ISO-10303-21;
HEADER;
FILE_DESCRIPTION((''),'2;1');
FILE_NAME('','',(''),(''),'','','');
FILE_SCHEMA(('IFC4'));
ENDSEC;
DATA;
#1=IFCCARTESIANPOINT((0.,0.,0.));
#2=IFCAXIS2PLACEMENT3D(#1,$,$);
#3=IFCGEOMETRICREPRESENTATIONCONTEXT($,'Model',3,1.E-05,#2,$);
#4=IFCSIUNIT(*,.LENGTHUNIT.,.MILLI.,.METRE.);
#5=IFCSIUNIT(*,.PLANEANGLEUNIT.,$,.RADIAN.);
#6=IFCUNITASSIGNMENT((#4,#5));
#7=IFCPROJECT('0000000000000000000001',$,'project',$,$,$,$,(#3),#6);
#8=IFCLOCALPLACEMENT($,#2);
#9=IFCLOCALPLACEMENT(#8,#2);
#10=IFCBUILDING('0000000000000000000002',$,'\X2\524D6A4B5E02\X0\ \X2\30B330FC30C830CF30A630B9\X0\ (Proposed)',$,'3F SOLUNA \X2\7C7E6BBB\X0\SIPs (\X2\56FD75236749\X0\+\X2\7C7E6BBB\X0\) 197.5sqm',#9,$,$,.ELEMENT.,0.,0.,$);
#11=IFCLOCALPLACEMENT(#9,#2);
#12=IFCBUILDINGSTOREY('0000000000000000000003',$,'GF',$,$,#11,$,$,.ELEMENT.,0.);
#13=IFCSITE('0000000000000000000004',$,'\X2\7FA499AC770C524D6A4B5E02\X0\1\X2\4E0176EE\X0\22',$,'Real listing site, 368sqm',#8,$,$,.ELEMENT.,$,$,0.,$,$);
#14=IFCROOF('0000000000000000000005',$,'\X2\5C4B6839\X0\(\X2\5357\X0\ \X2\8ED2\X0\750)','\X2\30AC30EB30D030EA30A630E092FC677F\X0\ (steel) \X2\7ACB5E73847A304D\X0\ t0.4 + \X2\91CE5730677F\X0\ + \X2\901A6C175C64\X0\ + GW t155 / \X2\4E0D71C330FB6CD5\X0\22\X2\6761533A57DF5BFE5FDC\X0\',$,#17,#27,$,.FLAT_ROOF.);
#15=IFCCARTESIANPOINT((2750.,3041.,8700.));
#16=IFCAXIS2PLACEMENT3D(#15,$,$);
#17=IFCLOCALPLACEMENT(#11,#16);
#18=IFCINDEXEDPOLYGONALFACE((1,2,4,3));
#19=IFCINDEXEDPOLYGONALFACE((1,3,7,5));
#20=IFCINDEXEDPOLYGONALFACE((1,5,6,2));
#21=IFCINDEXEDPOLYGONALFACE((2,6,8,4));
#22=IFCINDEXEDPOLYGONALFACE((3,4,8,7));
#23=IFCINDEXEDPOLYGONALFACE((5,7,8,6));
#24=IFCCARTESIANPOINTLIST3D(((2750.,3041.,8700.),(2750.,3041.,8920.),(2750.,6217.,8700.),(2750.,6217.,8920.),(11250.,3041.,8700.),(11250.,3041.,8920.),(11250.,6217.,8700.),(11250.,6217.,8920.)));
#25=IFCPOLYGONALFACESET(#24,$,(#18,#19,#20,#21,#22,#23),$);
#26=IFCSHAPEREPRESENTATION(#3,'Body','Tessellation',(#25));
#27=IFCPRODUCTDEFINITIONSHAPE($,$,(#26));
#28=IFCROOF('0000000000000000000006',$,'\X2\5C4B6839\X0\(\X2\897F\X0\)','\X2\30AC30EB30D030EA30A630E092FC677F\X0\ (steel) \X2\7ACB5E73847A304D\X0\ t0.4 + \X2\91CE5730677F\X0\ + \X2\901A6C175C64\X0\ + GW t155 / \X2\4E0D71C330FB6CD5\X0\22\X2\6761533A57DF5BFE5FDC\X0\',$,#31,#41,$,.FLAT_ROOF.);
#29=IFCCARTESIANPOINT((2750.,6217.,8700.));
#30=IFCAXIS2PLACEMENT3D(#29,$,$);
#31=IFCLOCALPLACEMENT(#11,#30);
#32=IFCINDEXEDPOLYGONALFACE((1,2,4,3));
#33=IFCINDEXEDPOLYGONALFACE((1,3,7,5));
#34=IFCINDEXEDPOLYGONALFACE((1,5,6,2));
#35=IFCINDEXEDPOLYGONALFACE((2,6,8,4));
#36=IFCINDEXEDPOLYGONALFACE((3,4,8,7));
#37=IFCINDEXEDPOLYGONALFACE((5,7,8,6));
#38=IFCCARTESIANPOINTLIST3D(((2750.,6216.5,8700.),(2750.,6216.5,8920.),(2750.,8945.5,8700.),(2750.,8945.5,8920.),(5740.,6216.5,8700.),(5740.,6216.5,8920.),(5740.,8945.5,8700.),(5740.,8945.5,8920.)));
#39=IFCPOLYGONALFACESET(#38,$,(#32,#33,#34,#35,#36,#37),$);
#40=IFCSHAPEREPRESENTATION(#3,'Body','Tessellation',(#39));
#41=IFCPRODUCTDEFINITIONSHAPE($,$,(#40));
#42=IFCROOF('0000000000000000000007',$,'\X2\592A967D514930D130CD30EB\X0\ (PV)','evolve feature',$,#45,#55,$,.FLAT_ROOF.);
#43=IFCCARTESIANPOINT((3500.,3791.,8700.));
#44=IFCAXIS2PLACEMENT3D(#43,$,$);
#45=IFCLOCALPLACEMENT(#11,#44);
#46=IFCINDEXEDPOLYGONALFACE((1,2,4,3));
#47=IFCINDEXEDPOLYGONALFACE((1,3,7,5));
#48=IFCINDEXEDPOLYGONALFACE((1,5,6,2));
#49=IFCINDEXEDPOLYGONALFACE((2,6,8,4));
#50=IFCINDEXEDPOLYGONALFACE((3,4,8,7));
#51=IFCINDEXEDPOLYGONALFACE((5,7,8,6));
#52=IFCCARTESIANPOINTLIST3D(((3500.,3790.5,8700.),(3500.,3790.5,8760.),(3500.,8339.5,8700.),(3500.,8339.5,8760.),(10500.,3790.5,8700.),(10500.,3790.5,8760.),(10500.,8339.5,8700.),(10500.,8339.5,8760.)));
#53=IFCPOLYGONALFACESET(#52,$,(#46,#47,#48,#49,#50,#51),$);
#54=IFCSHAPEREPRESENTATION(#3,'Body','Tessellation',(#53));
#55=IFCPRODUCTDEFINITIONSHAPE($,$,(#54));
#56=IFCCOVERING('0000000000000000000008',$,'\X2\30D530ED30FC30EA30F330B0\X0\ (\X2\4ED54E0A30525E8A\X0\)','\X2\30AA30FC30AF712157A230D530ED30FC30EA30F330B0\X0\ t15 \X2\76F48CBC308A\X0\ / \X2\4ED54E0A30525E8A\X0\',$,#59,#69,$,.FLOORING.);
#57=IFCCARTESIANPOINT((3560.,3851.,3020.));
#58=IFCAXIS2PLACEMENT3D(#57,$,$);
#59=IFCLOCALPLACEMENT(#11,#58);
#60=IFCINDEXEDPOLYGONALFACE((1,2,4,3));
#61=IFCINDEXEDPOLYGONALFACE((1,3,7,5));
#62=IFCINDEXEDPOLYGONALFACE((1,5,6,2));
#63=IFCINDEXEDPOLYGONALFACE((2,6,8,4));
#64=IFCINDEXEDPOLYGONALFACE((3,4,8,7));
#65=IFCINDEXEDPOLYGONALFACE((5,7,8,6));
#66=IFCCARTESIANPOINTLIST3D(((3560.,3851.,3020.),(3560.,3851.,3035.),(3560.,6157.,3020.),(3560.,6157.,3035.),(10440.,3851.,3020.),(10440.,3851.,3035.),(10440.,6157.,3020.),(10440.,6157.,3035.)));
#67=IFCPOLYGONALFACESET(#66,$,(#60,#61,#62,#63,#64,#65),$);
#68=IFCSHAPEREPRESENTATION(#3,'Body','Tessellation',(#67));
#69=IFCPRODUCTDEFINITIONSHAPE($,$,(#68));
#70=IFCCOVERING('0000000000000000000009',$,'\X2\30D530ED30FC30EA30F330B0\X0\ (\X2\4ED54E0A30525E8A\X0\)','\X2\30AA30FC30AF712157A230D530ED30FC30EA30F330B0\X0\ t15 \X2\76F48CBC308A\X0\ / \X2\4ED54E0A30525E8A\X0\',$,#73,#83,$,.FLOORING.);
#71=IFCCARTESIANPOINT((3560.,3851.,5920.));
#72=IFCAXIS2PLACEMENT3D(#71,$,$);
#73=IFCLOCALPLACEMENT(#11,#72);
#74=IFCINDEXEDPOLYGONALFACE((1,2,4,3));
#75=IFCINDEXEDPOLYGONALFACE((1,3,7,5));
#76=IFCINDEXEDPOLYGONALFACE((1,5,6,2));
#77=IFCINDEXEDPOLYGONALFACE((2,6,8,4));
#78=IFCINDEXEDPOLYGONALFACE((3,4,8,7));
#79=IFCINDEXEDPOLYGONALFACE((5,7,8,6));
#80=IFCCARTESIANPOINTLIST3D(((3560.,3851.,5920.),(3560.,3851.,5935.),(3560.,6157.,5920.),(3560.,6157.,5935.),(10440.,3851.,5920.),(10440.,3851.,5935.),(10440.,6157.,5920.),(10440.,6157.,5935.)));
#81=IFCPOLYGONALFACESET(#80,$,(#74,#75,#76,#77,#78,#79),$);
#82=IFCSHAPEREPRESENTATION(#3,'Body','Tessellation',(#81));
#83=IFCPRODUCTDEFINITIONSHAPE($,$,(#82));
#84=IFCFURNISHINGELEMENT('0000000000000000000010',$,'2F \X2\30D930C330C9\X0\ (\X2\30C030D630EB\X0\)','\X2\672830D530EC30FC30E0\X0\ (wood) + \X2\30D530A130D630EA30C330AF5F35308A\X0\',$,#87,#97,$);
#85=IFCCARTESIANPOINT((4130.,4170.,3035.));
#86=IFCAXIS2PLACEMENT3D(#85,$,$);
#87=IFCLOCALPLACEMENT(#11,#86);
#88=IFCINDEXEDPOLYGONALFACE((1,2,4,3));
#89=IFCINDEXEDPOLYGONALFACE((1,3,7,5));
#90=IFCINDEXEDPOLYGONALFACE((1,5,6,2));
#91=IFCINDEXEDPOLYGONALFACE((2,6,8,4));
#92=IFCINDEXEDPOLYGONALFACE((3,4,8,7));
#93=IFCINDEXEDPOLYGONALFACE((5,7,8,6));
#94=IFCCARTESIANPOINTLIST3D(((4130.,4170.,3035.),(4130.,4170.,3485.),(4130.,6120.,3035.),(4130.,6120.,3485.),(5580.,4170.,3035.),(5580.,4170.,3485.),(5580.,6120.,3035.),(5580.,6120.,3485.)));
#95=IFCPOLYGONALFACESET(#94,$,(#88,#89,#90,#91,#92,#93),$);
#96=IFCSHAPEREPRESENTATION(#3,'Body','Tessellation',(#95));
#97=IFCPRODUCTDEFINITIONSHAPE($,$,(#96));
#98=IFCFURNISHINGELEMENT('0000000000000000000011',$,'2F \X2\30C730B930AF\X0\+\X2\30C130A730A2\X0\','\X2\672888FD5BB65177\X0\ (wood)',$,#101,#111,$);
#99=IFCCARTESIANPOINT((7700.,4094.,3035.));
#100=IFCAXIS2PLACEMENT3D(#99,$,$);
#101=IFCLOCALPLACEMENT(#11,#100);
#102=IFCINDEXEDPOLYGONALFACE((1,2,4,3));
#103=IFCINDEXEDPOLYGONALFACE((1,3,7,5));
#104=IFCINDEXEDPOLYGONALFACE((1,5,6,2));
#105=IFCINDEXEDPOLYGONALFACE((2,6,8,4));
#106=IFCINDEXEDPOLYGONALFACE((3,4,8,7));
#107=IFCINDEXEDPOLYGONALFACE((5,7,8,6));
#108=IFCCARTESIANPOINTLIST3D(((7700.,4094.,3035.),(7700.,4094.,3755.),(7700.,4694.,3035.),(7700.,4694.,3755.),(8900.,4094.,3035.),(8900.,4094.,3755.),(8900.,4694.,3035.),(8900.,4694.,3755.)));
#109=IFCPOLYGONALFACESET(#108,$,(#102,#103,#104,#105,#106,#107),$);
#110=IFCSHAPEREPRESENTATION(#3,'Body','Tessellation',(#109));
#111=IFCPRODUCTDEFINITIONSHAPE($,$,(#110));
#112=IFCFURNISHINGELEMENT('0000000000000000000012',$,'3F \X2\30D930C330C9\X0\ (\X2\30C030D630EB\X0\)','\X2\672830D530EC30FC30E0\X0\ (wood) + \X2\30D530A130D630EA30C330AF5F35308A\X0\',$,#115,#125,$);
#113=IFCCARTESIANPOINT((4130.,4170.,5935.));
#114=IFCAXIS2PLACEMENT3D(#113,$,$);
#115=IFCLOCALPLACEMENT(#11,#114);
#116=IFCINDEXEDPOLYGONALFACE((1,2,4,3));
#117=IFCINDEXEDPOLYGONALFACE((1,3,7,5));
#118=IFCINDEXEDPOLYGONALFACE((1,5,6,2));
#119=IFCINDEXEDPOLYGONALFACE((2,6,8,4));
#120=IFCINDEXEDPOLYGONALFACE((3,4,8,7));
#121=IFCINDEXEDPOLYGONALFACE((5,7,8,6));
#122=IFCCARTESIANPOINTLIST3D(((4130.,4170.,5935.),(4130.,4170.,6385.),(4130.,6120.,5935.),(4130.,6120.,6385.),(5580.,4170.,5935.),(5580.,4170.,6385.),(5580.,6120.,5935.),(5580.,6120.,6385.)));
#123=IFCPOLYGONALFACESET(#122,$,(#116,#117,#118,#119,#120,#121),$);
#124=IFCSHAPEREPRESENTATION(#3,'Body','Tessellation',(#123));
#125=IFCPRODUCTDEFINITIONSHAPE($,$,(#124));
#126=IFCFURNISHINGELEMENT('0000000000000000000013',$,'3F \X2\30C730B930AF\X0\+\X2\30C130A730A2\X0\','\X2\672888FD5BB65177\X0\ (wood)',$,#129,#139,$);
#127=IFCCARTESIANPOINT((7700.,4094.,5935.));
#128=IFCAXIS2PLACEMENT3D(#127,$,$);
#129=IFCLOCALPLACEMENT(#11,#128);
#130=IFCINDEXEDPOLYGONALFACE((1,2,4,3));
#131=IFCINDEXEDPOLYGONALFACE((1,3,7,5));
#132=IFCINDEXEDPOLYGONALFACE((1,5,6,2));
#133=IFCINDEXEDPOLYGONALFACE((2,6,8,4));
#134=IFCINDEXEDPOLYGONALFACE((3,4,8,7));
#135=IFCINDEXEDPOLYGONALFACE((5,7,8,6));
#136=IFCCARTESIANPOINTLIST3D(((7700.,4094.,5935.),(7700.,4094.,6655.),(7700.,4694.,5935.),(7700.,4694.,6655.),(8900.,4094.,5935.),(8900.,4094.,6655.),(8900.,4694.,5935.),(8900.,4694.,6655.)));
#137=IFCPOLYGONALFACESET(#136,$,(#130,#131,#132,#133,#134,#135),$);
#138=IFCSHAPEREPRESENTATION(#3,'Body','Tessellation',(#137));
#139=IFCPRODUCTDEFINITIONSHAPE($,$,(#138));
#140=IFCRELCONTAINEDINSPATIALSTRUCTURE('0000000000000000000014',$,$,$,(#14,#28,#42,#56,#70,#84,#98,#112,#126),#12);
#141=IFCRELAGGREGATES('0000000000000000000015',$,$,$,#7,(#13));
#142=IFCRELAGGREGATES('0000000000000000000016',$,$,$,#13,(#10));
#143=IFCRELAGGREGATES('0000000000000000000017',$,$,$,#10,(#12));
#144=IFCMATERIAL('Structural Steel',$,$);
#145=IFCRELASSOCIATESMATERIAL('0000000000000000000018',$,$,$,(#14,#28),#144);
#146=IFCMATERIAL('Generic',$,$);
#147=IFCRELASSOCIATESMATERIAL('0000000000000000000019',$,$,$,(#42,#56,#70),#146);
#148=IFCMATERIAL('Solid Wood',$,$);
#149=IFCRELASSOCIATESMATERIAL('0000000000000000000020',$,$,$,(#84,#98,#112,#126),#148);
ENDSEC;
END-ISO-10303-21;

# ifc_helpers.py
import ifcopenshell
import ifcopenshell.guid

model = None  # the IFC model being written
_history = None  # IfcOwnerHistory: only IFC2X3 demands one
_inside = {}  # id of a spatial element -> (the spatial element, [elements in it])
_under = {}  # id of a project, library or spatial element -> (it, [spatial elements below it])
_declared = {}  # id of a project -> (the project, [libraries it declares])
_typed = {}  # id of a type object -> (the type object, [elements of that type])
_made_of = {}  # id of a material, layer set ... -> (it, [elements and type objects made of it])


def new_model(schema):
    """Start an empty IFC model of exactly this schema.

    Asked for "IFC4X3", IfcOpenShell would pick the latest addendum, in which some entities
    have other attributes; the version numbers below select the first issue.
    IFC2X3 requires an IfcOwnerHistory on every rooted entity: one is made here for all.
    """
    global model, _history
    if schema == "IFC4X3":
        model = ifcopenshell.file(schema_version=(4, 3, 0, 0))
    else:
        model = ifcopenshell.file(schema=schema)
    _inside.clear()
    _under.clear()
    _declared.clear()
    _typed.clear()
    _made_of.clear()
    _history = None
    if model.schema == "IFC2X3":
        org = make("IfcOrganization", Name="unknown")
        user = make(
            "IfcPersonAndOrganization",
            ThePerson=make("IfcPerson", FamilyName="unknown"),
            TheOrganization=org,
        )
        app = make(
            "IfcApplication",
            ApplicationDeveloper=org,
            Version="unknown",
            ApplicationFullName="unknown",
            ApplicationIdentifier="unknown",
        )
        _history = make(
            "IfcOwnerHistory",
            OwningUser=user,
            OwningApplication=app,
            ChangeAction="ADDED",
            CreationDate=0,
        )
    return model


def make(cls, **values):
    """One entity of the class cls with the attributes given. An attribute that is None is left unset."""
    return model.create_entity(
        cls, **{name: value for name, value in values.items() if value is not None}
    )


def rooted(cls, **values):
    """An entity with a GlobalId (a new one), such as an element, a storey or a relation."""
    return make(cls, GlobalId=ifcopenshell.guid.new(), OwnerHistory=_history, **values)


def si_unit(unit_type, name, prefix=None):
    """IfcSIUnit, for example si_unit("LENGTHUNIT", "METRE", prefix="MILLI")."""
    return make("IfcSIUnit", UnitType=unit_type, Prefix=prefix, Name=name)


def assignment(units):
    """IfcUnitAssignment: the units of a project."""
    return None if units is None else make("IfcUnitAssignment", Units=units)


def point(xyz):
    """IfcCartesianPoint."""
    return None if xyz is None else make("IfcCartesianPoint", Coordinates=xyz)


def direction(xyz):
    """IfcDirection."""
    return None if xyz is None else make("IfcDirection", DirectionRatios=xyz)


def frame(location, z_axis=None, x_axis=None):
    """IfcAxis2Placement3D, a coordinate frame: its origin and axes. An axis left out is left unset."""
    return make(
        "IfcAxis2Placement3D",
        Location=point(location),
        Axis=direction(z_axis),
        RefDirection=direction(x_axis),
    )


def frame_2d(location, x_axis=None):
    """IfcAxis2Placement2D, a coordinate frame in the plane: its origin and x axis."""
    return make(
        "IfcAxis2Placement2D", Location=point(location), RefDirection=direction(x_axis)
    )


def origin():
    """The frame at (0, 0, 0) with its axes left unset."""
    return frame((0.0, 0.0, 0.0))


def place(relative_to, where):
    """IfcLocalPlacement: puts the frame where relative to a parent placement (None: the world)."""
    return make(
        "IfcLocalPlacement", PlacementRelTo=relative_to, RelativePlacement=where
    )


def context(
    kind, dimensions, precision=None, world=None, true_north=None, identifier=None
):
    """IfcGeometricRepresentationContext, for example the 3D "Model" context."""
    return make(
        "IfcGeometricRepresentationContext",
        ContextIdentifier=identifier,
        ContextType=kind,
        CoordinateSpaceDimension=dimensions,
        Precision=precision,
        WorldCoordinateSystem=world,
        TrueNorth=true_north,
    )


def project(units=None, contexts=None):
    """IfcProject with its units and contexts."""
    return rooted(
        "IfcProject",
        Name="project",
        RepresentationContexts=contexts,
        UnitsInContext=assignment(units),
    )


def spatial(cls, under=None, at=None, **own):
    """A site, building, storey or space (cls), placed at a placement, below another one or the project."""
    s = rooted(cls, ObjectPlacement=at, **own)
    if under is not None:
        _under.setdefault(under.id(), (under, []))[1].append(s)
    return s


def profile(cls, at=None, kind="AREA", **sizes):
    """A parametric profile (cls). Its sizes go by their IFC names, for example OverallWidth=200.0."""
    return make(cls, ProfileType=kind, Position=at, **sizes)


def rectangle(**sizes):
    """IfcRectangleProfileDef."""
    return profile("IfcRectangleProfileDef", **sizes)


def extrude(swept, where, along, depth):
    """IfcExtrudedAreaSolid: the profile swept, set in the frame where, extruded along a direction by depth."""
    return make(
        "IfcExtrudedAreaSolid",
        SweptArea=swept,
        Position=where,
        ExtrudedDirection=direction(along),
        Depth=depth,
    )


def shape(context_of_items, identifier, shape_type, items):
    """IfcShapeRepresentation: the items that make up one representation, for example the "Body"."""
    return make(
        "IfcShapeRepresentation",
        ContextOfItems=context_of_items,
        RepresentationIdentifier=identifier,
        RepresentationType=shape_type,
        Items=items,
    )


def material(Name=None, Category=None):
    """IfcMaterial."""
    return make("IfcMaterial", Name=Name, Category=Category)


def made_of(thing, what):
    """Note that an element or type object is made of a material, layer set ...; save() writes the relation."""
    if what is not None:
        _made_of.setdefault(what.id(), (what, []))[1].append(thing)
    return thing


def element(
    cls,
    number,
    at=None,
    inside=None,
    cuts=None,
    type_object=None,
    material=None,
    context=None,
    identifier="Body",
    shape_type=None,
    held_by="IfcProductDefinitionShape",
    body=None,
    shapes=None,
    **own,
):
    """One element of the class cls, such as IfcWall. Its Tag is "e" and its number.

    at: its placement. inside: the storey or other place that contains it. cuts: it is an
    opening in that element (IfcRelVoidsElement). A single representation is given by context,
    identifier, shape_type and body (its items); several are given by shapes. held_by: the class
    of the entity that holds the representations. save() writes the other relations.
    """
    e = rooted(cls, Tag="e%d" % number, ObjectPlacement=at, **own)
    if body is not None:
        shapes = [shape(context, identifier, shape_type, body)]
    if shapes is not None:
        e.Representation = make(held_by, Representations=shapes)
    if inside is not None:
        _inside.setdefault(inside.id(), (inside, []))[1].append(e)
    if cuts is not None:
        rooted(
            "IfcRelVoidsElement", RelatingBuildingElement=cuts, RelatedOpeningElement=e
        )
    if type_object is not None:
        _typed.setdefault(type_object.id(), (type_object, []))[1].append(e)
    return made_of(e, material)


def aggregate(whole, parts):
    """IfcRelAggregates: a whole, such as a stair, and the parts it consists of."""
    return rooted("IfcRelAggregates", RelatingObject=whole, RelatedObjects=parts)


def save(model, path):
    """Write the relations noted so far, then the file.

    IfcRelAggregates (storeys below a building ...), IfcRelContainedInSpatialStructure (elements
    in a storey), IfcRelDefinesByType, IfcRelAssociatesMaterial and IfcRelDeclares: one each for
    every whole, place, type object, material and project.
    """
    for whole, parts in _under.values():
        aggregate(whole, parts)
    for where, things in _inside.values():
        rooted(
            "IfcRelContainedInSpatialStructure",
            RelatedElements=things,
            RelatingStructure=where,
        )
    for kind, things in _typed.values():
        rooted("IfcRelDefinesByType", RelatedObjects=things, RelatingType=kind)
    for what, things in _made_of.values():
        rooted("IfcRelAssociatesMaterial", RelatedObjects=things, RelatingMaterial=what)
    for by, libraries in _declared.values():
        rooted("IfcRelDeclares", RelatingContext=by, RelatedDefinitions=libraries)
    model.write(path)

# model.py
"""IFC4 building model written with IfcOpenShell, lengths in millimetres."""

from ifc_helpers import new_model, si_unit, frame, frame_2d, origin, place, context, project, spatial, rectangle, extrude, material, element, save


model = new_model("IFC4")

# Units and contexts
model_context = context("Model", 3, precision=1e-05, world=origin())
ifc_project = project(units=[si_unit("LENGTHUNIT", "METRE", prefix="MILLI"), si_unit("PLANEANGLEUNIT", "RADIAN")], contexts=[model_context])

# Site, building, storey
site_placement = place(None, origin())
site = spatial("IfcSite", under=ifc_project, at=site_placement, Name="群馬県前橋市1丁目22", ObjectType="Real listing site, 368sqm", CompositionType="ELEMENT", RefElevation=0.0)
building_placement = place(site_placement, origin())
building = spatial("IfcBuilding", under=site, at=building_placement, Name="前橋市 コートハウス (Proposed)", ObjectType="3F SOLUNA 籾殻SIPs (国産杉+籾殻) 197.5sqm", CompositionType="ELEMENT", ElevationOfRefHeight=0.0, ElevationOfTerrain=0.0)
storey_placement = place(building_placement, origin())
storey = spatial("IfcBuildingStorey", under=building, at=storey_placement, Name="GF", CompositionType="ELEMENT", Elevation=0.0)

# Shared definitions
ifc_material_1 = material(Name="Solid Wood")

# Roofs
ifc_material_2 = material(Name="Structural Steel")
roof_1_placement = place(storey_placement, frame((2750.0, 3041.0, 8700.0)))
element("IfcRoof", 1, at=roof_1_placement, inside=storey, material=ifc_material_2, Name="屋根(南 軒750)", Description="ガルバリウム鋼板 (steel) 立平葺き t0.4 + 野地板 + 通気層 + GW t155 / 不燃・法22条区域対応", PredefinedType="FLAT_ROOF", context=model_context, shape_type="SweptSolid", body=[
    extrude(rectangle(XDim=8500.0, YDim=3176.0, at=frame_2d((4250.0, 1588.0))), frame((2750.0, 3041.0, 8700.0)), (0.0, 0.0, 1.0), 220.0),
])
roof_2_placement = place(storey_placement, frame((2750.0, 6217.0, 8700.0)))
element("IfcRoof", 2, at=roof_2_placement, inside=storey, material=ifc_material_2, Name="屋根(西)", Description="ガルバリウム鋼板 (steel) 立平葺き t0.4 + 野地板 + 通気層 + GW t155 / 不燃・法22条区域対応", PredefinedType="FLAT_ROOF", context=model_context, shape_type="SweptSolid", body=[
    extrude(rectangle(XDim=2990.0, YDim=2729.0, at=frame_2d((1495.0, 1364.0))), frame((2750.0, 6217.0, 8700.0)), (0.0, 0.0, 1.0), 220.0),
])
ifc_material_3 = material(Name="Generic")
roof_3_placement = place(storey_placement, frame((3500.0, 3791.0, 8700.0)))
element("IfcRoof", 3, at=roof_3_placement, inside=storey, material=ifc_material_3, Name="太陽光パネル (PV)", Description="evolve feature", PredefinedType="FLAT_ROOF", context=model_context, shape_type="SweptSolid", body=[
    extrude(rectangle(XDim=7000.0, YDim=4549.0, at=frame_2d((3500.0, 2274.0))), frame((3500.0, 3791.0, 8700.0)), (0.0, 0.0, 1.0), 60.0),
])

# Coverings
covering_1_placement = place(storey_placement, frame((3560.0, 3851.0, 3020.0)))
element("IfcCovering", 4, at=covering_1_placement, inside=storey, material=ifc_material_3, Name="フローリング (仕上げ床)", Description="オーク無垢フローリング t15 直貼り / 仕上げ床", PredefinedType="FLOORING", context=model_context, shape_type="SweptSolid", body=[
    extrude(rectangle(XDim=6880.0, YDim=2306.0, at=frame_2d((3440.0, 1153.0))), frame((3560.0, 3851.0, 3020.0)), (0.0, 0.0, 1.0), 15.0),
])
covering_2_placement = place(storey_placement, frame((3560.0, 3851.0, 5920.0)))
element("IfcCovering", 5, at=covering_2_placement, inside=storey, material=ifc_material_3, Name="フローリング (仕上げ床)", Description="オーク無垢フローリング t15 直貼り / 仕上げ床", PredefinedType="FLOORING", context=model_context, shape_type="SweptSolid", body=[
    extrude(rectangle(XDim=6880.0, YDim=2306.0, at=frame_2d((3440.0, 1153.0))), frame((3560.0, 3851.0, 5920.0)), (0.0, 0.0, 1.0), 15.0),
])

# Furnishing elements
furnishing_1_placement = place(storey_placement, frame((4130.0, 4170.0, 3035.0)))
element("IfcFurnishingElement", 6, at=furnishing_1_placement, inside=storey, material=ifc_material_1, Name="2F ベッド (ダブル)", Description="木フレーム (wood) + ファブリック張り", context=model_context, shape_type="SweptSolid", body=[
    extrude(rectangle(XDim=1450.0, YDim=1950.0, at=frame_2d((725.0, 975.0))), frame((4130.0, 4170.0, 3035.0)), (0.0, 0.0, 1.0), 450.0),
])
furnishing_2_placement = place(storey_placement, frame((7700.0, 4094.0, 3035.0)))
element("IfcFurnishingElement", 7, at=furnishing_2_placement, inside=storey, material=ifc_material_1, Name="2F デスク+チェア", Description="木製家具 (wood)", context=model_context, shape_type="SweptSolid", body=[
    extrude(rectangle(XDim=1200.0, YDim=600.0, at=frame_2d((600.0, 300.0))), frame((7700.0, 4094.0, 3035.0)), (0.0, 0.0, 1.0), 720.0),
])
furnishing_3_placement = place(storey_placement, frame((4130.0, 4170.0, 5935.0)))
element("IfcFurnishingElement", 8, at=furnishing_3_placement, inside=storey, material=ifc_material_1, Name="3F ベッド (ダブル)", Description="木フレーム (wood) + ファブリック張り", context=model_context, shape_type="SweptSolid", body=[
    extrude(rectangle(XDim=1450.0, YDim=1950.0, at=frame_2d((725.0, 975.0))), frame((4130.0, 4170.0, 5935.0)), (0.0, 0.0, 1.0), 450.0),
])
furnishing_4_placement = place(storey_placement, frame((7700.0, 4094.0, 5935.0)))
element("IfcFurnishingElement", 9, at=furnishing_4_placement, inside=storey, material=ifc_material_1, Name="3F デスク+チェア", Description="木製家具 (wood)", context=model_context, shape_type="SweptSolid", body=[
    extrude(rectangle(XDim=1200.0, YDim=600.0, at=frame_2d((600.0, 300.0))), frame((7700.0, 4094.0, 5935.0)), (0.0, 0.0, 1.0), 720.0),
])

save(model, "model.ifc")
